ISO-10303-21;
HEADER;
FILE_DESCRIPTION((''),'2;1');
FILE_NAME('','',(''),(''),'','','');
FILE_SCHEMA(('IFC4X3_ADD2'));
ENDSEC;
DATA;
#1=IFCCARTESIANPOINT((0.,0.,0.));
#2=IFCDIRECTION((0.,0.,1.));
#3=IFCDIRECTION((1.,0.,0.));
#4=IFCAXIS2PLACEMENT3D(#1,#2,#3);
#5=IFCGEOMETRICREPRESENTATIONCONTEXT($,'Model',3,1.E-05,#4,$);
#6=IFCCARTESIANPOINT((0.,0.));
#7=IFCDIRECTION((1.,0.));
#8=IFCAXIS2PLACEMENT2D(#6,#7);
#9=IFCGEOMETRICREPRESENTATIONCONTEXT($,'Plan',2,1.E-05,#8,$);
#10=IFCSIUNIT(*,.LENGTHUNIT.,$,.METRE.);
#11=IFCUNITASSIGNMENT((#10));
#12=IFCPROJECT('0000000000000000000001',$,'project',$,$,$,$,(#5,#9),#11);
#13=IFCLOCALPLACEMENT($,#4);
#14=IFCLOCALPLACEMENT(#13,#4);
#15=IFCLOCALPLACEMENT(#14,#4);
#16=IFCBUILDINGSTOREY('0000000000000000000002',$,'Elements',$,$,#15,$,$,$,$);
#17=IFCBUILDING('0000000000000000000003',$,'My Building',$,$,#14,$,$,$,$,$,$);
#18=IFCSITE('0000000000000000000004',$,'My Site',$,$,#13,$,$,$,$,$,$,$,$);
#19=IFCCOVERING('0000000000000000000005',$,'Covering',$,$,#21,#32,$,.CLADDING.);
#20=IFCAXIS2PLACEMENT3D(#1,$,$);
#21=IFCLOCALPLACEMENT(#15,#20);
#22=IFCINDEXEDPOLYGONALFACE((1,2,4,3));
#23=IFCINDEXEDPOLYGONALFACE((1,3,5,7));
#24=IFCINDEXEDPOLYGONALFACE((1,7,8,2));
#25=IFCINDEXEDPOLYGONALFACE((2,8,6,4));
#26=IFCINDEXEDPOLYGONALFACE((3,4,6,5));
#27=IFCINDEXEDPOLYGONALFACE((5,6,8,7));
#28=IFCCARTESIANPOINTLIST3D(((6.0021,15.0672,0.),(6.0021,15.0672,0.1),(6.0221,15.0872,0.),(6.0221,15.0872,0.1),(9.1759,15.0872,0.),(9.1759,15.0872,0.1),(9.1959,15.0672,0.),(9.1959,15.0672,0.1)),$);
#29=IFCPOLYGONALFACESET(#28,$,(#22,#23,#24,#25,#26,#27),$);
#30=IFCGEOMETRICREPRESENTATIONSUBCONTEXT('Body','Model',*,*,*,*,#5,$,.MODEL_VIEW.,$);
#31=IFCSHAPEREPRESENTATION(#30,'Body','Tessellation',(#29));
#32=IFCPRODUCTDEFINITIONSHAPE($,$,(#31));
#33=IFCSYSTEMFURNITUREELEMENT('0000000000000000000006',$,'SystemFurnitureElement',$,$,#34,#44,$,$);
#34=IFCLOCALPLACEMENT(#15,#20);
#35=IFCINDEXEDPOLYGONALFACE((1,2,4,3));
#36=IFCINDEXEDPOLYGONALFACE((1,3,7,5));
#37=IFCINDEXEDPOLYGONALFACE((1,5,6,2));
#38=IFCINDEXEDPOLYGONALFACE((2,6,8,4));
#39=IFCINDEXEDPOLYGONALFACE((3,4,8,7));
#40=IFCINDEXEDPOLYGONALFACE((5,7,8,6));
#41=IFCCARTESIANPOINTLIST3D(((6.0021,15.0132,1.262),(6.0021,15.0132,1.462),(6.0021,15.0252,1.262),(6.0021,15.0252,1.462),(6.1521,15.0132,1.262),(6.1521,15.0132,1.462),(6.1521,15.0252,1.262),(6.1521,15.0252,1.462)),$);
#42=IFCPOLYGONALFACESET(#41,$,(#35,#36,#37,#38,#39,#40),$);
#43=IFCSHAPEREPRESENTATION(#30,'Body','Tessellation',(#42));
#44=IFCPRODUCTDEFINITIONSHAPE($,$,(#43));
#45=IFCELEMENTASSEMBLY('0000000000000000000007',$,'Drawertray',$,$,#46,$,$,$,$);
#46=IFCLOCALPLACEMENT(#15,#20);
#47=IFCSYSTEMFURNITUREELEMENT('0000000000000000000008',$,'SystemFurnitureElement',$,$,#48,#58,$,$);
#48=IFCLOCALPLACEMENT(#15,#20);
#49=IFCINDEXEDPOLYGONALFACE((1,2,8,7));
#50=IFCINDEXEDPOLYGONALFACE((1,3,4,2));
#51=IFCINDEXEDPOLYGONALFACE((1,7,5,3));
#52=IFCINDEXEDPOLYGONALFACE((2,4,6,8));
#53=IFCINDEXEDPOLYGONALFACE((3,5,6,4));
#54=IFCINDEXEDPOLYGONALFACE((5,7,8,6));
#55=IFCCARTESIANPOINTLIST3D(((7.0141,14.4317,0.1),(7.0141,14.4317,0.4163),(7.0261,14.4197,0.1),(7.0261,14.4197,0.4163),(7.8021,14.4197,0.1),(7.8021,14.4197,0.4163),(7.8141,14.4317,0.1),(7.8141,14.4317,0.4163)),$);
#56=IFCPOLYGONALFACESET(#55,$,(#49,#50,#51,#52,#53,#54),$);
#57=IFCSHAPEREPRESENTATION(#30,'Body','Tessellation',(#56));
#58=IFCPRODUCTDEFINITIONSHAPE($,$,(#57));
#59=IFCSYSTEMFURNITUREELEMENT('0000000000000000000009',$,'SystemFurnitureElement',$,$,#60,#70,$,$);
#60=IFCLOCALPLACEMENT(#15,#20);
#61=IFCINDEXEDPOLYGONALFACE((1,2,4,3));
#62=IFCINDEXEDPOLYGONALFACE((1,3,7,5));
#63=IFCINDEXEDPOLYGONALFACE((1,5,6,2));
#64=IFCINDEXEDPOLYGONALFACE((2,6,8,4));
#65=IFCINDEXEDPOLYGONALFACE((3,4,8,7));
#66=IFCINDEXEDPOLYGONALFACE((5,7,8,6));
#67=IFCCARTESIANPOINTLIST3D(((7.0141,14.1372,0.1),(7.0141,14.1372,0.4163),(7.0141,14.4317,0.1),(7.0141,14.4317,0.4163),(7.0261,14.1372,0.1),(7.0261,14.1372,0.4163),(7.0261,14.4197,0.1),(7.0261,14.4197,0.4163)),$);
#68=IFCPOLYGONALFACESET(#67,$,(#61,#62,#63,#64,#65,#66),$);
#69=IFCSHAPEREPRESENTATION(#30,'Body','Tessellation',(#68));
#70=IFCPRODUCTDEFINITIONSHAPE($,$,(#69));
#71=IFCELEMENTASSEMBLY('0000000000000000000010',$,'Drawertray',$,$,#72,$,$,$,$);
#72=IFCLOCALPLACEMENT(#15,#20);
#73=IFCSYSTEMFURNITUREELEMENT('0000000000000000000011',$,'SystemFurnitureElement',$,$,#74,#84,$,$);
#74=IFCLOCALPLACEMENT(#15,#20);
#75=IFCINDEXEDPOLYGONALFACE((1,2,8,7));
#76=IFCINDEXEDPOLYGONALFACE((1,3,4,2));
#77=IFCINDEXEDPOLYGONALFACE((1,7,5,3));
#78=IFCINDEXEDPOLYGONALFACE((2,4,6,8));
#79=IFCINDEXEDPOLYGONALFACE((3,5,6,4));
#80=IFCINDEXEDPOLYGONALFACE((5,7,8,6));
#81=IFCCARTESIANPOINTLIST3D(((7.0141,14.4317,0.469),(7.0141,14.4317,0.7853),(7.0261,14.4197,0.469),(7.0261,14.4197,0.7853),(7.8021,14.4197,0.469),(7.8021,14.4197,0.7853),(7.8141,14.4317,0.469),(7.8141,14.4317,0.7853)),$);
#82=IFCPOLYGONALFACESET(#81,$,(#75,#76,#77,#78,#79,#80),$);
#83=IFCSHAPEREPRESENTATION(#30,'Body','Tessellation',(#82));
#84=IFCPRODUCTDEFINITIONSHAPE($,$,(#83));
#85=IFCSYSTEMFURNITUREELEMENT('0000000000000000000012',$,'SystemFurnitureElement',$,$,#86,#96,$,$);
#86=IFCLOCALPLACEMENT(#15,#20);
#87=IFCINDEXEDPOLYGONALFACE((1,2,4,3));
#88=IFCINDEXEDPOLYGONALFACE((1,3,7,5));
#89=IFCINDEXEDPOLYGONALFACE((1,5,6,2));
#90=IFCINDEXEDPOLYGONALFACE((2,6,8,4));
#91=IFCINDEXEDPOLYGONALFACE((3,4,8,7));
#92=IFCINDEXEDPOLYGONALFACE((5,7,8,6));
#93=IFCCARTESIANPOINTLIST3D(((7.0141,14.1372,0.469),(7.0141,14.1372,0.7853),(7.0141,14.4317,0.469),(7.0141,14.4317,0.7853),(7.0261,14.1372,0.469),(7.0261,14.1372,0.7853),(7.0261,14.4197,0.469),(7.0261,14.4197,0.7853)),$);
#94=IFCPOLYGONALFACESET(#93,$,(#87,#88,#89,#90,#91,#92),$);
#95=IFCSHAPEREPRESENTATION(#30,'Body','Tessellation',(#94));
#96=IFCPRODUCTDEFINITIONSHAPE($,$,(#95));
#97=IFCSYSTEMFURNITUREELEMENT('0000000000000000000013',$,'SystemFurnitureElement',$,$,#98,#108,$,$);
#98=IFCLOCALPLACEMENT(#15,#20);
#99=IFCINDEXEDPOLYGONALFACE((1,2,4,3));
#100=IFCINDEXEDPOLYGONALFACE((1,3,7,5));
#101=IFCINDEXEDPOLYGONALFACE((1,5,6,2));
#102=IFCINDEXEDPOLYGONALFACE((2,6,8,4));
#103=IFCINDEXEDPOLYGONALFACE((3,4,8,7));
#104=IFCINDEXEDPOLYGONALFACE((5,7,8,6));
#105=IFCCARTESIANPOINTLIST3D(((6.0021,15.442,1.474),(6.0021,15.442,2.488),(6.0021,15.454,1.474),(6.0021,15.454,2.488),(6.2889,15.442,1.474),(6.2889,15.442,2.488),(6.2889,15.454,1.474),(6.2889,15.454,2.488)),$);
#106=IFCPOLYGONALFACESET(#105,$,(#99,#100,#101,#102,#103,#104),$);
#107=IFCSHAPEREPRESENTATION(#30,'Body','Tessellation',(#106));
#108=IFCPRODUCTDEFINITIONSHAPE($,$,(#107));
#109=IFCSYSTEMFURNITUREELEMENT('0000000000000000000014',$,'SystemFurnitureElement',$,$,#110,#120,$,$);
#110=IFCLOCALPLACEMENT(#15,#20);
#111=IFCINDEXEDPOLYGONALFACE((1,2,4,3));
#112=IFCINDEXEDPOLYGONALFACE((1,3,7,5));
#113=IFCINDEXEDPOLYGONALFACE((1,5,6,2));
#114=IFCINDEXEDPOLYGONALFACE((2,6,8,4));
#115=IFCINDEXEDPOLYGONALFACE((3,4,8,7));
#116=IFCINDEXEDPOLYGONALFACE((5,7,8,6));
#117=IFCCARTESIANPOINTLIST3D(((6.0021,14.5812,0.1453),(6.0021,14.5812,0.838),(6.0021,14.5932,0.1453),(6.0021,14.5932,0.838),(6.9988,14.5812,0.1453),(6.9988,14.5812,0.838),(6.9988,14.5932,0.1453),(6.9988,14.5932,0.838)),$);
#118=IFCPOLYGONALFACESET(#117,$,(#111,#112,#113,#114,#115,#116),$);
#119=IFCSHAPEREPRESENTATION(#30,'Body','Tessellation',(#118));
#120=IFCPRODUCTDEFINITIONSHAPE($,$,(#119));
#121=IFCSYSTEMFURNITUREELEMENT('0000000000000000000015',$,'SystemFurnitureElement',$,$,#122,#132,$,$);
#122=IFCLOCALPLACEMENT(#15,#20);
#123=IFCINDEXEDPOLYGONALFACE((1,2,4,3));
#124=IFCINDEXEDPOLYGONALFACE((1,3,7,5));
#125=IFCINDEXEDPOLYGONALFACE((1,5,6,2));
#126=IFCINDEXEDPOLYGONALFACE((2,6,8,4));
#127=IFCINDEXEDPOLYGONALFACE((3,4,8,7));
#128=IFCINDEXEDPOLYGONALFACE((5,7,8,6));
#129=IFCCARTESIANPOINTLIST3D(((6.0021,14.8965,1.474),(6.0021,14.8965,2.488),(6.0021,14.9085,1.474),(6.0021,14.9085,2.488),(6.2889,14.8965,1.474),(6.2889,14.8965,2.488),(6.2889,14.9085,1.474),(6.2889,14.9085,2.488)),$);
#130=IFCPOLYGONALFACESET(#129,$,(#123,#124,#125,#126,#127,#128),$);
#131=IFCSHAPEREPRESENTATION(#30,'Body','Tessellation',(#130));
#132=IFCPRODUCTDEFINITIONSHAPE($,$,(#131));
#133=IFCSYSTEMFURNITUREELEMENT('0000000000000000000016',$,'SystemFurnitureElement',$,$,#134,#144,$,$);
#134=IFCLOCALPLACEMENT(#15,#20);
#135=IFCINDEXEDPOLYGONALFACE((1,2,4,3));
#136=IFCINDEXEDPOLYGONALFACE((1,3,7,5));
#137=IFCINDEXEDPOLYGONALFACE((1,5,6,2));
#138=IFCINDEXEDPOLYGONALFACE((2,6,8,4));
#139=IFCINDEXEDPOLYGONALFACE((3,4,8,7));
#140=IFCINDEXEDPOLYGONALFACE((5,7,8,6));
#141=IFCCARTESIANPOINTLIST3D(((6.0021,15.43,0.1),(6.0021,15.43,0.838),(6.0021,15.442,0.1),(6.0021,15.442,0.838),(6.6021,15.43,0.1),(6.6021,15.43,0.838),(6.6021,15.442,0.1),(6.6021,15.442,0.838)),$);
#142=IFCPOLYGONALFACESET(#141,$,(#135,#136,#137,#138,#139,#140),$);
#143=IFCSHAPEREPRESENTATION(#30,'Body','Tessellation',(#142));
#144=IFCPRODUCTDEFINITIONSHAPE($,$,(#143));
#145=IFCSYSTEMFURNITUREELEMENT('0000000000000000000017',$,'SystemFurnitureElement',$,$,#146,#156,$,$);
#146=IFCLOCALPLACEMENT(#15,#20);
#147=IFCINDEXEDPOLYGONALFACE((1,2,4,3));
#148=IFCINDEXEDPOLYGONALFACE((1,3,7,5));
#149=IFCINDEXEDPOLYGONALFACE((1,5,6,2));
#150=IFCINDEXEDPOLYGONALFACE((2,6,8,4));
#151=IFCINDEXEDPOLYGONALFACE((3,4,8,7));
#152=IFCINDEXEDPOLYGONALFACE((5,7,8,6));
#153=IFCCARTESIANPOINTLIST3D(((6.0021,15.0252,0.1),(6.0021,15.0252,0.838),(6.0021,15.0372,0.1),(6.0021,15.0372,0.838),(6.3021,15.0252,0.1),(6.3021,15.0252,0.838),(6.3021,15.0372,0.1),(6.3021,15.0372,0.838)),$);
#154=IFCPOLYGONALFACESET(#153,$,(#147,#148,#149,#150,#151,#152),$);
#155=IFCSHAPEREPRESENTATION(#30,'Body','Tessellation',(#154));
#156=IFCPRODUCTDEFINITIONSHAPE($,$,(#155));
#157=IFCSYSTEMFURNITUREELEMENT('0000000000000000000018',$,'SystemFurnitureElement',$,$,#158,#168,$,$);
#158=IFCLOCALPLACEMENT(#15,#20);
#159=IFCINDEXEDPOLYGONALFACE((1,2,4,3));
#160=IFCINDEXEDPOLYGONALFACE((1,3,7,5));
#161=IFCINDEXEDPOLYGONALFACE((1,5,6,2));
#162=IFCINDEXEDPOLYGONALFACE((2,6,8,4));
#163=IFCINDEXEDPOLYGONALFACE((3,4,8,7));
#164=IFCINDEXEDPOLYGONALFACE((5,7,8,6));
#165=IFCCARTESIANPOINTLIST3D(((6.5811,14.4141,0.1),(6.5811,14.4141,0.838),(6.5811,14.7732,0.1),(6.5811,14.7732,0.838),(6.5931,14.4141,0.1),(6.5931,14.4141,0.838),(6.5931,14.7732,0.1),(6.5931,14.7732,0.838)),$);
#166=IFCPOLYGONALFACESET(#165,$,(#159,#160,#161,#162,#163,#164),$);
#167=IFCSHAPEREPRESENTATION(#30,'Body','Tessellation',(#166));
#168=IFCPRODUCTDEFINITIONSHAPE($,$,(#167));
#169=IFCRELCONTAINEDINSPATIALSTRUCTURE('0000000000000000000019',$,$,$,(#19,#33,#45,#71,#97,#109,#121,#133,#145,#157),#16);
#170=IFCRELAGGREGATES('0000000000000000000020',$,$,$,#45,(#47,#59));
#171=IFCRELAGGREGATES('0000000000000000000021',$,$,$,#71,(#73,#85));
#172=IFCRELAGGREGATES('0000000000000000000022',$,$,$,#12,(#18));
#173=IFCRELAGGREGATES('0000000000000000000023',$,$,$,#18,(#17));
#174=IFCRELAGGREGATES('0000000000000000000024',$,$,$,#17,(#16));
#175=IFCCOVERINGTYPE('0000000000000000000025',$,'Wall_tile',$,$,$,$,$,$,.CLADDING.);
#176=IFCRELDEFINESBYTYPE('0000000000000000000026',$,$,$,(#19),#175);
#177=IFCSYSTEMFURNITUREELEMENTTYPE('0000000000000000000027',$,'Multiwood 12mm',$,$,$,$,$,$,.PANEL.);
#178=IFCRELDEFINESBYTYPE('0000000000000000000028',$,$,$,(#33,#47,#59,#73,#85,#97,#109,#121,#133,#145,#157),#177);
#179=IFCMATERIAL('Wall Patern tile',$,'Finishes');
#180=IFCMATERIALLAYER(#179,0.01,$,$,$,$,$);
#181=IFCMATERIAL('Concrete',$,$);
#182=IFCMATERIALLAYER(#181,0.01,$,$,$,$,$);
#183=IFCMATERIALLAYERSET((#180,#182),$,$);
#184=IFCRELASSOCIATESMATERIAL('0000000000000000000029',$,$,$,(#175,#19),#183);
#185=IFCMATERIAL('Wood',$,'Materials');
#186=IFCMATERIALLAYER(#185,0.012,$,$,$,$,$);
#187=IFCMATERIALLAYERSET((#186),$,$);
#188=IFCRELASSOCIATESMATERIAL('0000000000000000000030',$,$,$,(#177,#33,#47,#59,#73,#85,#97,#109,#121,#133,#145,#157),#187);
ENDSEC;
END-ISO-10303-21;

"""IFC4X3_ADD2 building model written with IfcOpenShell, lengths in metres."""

from ifc_helpers import new_model, si_unit, frame, origin_with_axes, origin_2d_with_axis, place, context, subcontext, project, spatial, line, indexed_curve, outline, extrude, material, layer, layer_set, layer_usage, type_object, element, aggregate, save


model = new_model("IFC4X3_ADD2")

# Units and contexts
model_context = context("Model", 3, precision=1e-05, world=origin_with_axes())
plan_context = context("Plan", 2, precision=1e-05, world=origin_2d_with_axis())
body_context = subcontext(model_context, "Body", "Model", "MODEL_VIEW")
ifc_project = project(units=[si_unit("LENGTHUNIT", "METRE")], contexts=[model_context, plan_context])

# Site, building, storey
site_placement = place(None, origin_with_axes())
site = spatial("IfcSite", under=ifc_project, at=site_placement, Name="My Site")
building_placement = place(site_placement, origin_with_axes())
building = spatial("IfcBuilding", under=site, at=building_placement, Name="My Building")
storey_placement = place(building_placement, origin_with_axes())
storey = spatial("IfcBuildingStorey", under=building, at=storey_placement, Name="Elements")

# Covering
ifc_material_1 = material(Name="Wall Patern tile", Category="Finishes")
ifc_layer_1 = layer(ifc_material_1, 0.01)
ifc_material_2 = material(Name="Concrete")
ifc_layer_2 = layer(ifc_material_2, 0.01)
ifc_layer_set_1 = layer_set([ifc_layer_1, ifc_layer_2])
ifc_layer_usage_1 = layer_usage(ifc_layer_set_1, "AXIS2", "POSITIVE", 0.0)
covering_type_1 = type_object("IfcCoveringType", Name="Wall_tile", PredefinedType="CLADDING", material=ifc_layer_set_1)
covering_1_placement = place(storey_placement, frame((6.0221, 15.0672, 0.0), z_axis=(0.0, 0.0, 1.0), x_axis=(1.0, 0.0, 0.0)))
element("IfcCovering", 1, at=covering_1_placement, inside=storey, type_object=covering_type_1, material=ifc_layer_usage_1, Name="Covering", PredefinedType="CLADDING", context=body_context, shape_type="SweptSolid", body=[
    extrude(outline(indexed_curve([(-0.02, 0.0), (0.0, 0.02), (3.1538, 0.02), (3.1738, 0.0)], segments=[line(1, 2, 3, 4, 1)])), origin_with_axes(), (0.0, 0.0, 1.0), 0.1),
])

# System furniture element
ifc_material_3 = material(Name="Wood", Category="Materials")
ifc_layer_3 = layer(ifc_material_3, 0.012)
ifc_layer_set_2 = layer_set([ifc_layer_3])
ifc_layer_usage_2 = layer_usage(ifc_layer_set_2, "AXIS2", "POSITIVE", 0.0)
system_furniture_element_type_1 = type_object("IfcSystemFurnitureElementType", Name="Multiwood 12mm", PredefinedType="PANEL", material=ifc_layer_set_2)
system_furniture_element_1_placement = place(storey_placement, frame((6.1521, 15.0252, 1.262), z_axis=(0.0, 0.0, 1.0), x_axis=(-1.0, 0.000001, 0.0)))
element("IfcSystemFurnitureElement", 2, at=system_furniture_element_1_placement, inside=storey, type_object=system_furniture_element_type_1, material=ifc_layer_usage_2, Name="SystemFurnitureElement", context=body_context, shape_type="SweptSolid", body=[
    extrude(outline(indexed_curve([(0.0, 0.0), (0.0, 0.012), (0.15, 0.012), (0.15, 0.0)], segments=[line(1, 2, 3, 4, 1)])), origin_with_axes(), (0.0, 0.0, 1.0), 0.2),
])

# Element assemblies, system furniture elements
assembly_1_placement = place(storey_placement, frame((7.0141, 14.1372, 0.1), z_axis=(0.0, 0.0, 1.0), x_axis=(-1.0, 0.0, 0.0)))
assembly_1 = element("IfcElementAssembly", 3, at=assembly_1_placement, inside=storey, Name="Drawertray")
ifc_layer_usage_3 = layer_usage(ifc_layer_set_2, "AXIS2", "POSITIVE", 0.0)
system_furniture_element_2_placement = place(assembly_1_placement, frame((0.0, -0.2825, 0.0), z_axis=(0.0, 0.0, 1.0), x_axis=(-1.0, 0.0, 0.0)))
system_furniture_element_2 = element("IfcSystemFurnitureElement", 4, at=system_furniture_element_2_placement, type_object=system_furniture_element_type_1, material=ifc_layer_usage_3, Name="SystemFurnitureElement", context=body_context, shape_type="SweptSolid", body=[
    extrude(outline(indexed_curve([(0.012, 0.0), (0.0, 0.012), (0.8, 0.012), (0.788, 0.0)], segments=[line(1, 2, 3, 4, 1)])), origin_with_axes(), (0.0, 0.0, 1.0), 0.3163),
])
ifc_layer_usage_4 = layer_usage(ifc_layer_set_2, "AXIS2", "POSITIVE", 0.0)
system_furniture_element_3_placement = place(assembly_1_placement, frame((0.0, -0.2825, 0.0), z_axis=(0.0, 0.0, 1.0), x_axis=(0.000001, 1.0, 0.0)))
system_furniture_element_3 = element("IfcSystemFurnitureElement", 5, at=system_furniture_element_3_placement, type_object=system_furniture_element_type_1, material=ifc_layer_usage_4, Name="SystemFurnitureElement", context=body_context, shape_type="SweptSolid", body=[
    extrude(outline(indexed_curve([(-0.012, 0.0), (0.0, 0.012), (0.2825, 0.012), (0.2825, 0.0)], segments=[line(1, 2, 3, 4, 1)])), origin_with_axes(), (0.0, 0.0, 1.0), 0.3163),
])
aggregate(assembly_1, [system_furniture_element_2, system_furniture_element_3])
assembly_2_placement = place(storey_placement, frame((7.0141, 14.1372, 0.469), z_axis=(0.0, 0.0, 1.0), x_axis=(-1.0, 0.0, 0.0)))
assembly_2 = element("IfcElementAssembly", 6, at=assembly_2_placement, inside=storey, Name="Drawertray")
ifc_layer_usage_5 = layer_usage(ifc_layer_set_2, "AXIS2", "POSITIVE", 0.0)
system_furniture_element_4_placement = place(assembly_2_placement, frame((0.0, -0.2825, 0.0), z_axis=(0.0, 0.0, 1.0), x_axis=(-1.0, 0.0, 0.0)))
system_furniture_element_4 = element("IfcSystemFurnitureElement", 7, at=system_furniture_element_4_placement, type_object=system_furniture_element_type_1, material=ifc_layer_usage_5, Name="SystemFurnitureElement", context=body_context, shape_type="SweptSolid", body=[
    extrude(outline(indexed_curve([(0.012, 0.0), (0.0, 0.012), (0.8, 0.012), (0.788, 0.0)], segments=[line(1, 2, 3, 4, 1)])), origin_with_axes(), (0.0, 0.0, 1.0), 0.3163),
])
ifc_layer_usage_6 = layer_usage(ifc_layer_set_2, "AXIS2", "POSITIVE", 0.0)
system_furniture_element_5_placement = place(assembly_2_placement, frame((0.0, -0.2825, 0.0), z_axis=(0.0, 0.0, 1.0), x_axis=(0.000001, 1.0, 0.0)))
system_furniture_element_5 = element("IfcSystemFurnitureElement", 8, at=system_furniture_element_5_placement, type_object=system_furniture_element_type_1, material=ifc_layer_usage_6, Name="SystemFurnitureElement", context=body_context, shape_type="SweptSolid", body=[
    extrude(outline(indexed_curve([(-0.012, 0.0), (0.0, 0.012), (0.2825, 0.012), (0.2825, 0.0)], segments=[line(1, 2, 3, 4, 1)])), origin_with_axes(), (0.0, 0.0, 1.0), 0.3163),
])
aggregate(assembly_2, [system_furniture_element_4, system_furniture_element_5])

# System furniture elements
ifc_layer_usage_7 = layer_usage(ifc_layer_set_2, "AXIS2", "NEGATIVE", 0.0)
system_furniture_element_6_placement = place(storey_placement, frame((6.2889, 15.442, 1.474), z_axis=(0.0, 0.0, 1.0), x_axis=(-1.0, 0.0, 0.0)))
element("IfcSystemFurnitureElement", 9, at=system_furniture_element_6_placement, inside=storey, type_object=system_furniture_element_type_1, material=ifc_layer_usage_7, Name="SystemFurnitureElement", context=body_context, shape_type="SweptSolid", body=[
    extrude(outline(indexed_curve([(0.0, -0.012), (0.0, 0.0), (0.2869, 0.0), (0.2869, -0.012)], segments=[line(1, 2, 3, 4, 1)])), origin_with_axes(), (0.0, 0.0, 1.0), 1.014),
])
ifc_layer_usage_8 = layer_usage(ifc_layer_set_2, "AXIS2", "POSITIVE", 0.0)
system_furniture_element_7_placement = place(storey_placement, frame((6.0021, 14.5812, 0.1453), z_axis=(0.0, 0.0, 1.0), x_axis=(1.0, 0.0, 0.0)))
element("IfcSystemFurnitureElement", 10, at=system_furniture_element_7_placement, inside=storey, type_object=system_furniture_element_type_1, material=ifc_layer_usage_8, Name="SystemFurnitureElement", context=body_context, shape_type="SweptSolid", body=[
    extrude(outline(indexed_curve([(0.0, 0.0), (0.0, 0.012), (0.9967, 0.012), (0.9967, 0.0)], segments=[line(1, 2, 3, 4, 1)])), origin_with_axes(), (0.0, 0.0, 1.0), 0.6927),
])
ifc_layer_usage_9 = layer_usage(ifc_layer_set_2, "AXIS2", "NEGATIVE", 0.0)
system_furniture_element_8_placement = place(storey_placement, frame((6.2889, 14.8965, 1.474), z_axis=(0.0, 0.0, 1.0), x_axis=(-1.0, 0.0, 0.0)))
element("IfcSystemFurnitureElement", 11, at=system_furniture_element_8_placement, inside=storey, type_object=system_furniture_element_type_1, material=ifc_layer_usage_9, Name="SystemFurnitureElement", context=body_context, shape_type="SweptSolid", body=[
    extrude(outline(indexed_curve([(0.0, -0.012), (0.0, 0.0), (0.2869, 0.0), (0.2869, -0.012)], segments=[line(1, 2, 3, 4, 1)])), origin_with_axes(), (0.0, 0.0, 1.0), 1.014),
])
ifc_layer_usage_10 = layer_usage(ifc_layer_set_2, "AXIS2", "POSITIVE", 0.0)
system_furniture_element_9_placement = place(storey_placement, frame((6.0021, 15.43, 0.1), z_axis=(0.0, 0.0, 1.0), x_axis=(1.0, 0.0, 0.0)))
element("IfcSystemFurnitureElement", 12, at=system_furniture_element_9_placement, inside=storey, type_object=system_furniture_element_type_1, material=ifc_layer_usage_10, Name="SystemFurnitureElement", context=body_context, shape_type="SweptSolid", body=[
    extrude(outline(indexed_curve([(0.0, 0.0), (0.0, 0.012), (0.6, 0.012), (0.6, 0.0)], segments=[line(1, 2, 3, 4, 1)])), origin_with_axes(), (0.0, 0.0, 1.0), 0.738),
])
ifc_layer_usage_11 = layer_usage(ifc_layer_set_2, "AXIS2", "POSITIVE", 0.0)
system_furniture_element_10_placement = place(storey_placement, frame((6.0021, 15.0252, 0.1), z_axis=(0.0, 0.0, 1.0), x_axis=(1.0, 0.0, 0.0)))
element("IfcSystemFurnitureElement", 13, at=system_furniture_element_10_placement, inside=storey, type_object=system_furniture_element_type_1, material=ifc_layer_usage_11, Name="SystemFurnitureElement", context=body_context, shape_type="SweptSolid", body=[
    extrude(outline(indexed_curve([(0.0, 0.0), (0.0, 0.012), (0.3, 0.012), (0.3, 0.0)], segments=[line(1, 2, 3, 4, 1)])), origin_with_axes(), (0.0, 0.0, 1.0), 0.738),
])
ifc_layer_usage_12 = layer_usage(ifc_layer_set_2, "AXIS2", "POSITIVE", 0.0)
system_furniture_element_11_placement = place(storey_placement, frame((6.5811, 14.7732, 0.1), z_axis=(0.0, 0.0, 1.0), x_axis=(0.0, -1.0, 0.0)))
element("IfcSystemFurnitureElement", 14, at=system_furniture_element_11_placement, inside=storey, type_object=system_furniture_element_type_1, material=ifc_layer_usage_12, Name="SystemFurnitureElement", context=body_context, shape_type="SweptSolid", body=[
    extrude(outline(indexed_curve([(0.0, 0.0), (0.0, 0.012), (0.3591, 0.012), (0.3591, 0.0)], segments=[line(1, 2, 3, 4, 1)])), origin_with_axes(), (0.0, 0.0, 1.0), 0.738),
])

save(model, "model.ifc")
